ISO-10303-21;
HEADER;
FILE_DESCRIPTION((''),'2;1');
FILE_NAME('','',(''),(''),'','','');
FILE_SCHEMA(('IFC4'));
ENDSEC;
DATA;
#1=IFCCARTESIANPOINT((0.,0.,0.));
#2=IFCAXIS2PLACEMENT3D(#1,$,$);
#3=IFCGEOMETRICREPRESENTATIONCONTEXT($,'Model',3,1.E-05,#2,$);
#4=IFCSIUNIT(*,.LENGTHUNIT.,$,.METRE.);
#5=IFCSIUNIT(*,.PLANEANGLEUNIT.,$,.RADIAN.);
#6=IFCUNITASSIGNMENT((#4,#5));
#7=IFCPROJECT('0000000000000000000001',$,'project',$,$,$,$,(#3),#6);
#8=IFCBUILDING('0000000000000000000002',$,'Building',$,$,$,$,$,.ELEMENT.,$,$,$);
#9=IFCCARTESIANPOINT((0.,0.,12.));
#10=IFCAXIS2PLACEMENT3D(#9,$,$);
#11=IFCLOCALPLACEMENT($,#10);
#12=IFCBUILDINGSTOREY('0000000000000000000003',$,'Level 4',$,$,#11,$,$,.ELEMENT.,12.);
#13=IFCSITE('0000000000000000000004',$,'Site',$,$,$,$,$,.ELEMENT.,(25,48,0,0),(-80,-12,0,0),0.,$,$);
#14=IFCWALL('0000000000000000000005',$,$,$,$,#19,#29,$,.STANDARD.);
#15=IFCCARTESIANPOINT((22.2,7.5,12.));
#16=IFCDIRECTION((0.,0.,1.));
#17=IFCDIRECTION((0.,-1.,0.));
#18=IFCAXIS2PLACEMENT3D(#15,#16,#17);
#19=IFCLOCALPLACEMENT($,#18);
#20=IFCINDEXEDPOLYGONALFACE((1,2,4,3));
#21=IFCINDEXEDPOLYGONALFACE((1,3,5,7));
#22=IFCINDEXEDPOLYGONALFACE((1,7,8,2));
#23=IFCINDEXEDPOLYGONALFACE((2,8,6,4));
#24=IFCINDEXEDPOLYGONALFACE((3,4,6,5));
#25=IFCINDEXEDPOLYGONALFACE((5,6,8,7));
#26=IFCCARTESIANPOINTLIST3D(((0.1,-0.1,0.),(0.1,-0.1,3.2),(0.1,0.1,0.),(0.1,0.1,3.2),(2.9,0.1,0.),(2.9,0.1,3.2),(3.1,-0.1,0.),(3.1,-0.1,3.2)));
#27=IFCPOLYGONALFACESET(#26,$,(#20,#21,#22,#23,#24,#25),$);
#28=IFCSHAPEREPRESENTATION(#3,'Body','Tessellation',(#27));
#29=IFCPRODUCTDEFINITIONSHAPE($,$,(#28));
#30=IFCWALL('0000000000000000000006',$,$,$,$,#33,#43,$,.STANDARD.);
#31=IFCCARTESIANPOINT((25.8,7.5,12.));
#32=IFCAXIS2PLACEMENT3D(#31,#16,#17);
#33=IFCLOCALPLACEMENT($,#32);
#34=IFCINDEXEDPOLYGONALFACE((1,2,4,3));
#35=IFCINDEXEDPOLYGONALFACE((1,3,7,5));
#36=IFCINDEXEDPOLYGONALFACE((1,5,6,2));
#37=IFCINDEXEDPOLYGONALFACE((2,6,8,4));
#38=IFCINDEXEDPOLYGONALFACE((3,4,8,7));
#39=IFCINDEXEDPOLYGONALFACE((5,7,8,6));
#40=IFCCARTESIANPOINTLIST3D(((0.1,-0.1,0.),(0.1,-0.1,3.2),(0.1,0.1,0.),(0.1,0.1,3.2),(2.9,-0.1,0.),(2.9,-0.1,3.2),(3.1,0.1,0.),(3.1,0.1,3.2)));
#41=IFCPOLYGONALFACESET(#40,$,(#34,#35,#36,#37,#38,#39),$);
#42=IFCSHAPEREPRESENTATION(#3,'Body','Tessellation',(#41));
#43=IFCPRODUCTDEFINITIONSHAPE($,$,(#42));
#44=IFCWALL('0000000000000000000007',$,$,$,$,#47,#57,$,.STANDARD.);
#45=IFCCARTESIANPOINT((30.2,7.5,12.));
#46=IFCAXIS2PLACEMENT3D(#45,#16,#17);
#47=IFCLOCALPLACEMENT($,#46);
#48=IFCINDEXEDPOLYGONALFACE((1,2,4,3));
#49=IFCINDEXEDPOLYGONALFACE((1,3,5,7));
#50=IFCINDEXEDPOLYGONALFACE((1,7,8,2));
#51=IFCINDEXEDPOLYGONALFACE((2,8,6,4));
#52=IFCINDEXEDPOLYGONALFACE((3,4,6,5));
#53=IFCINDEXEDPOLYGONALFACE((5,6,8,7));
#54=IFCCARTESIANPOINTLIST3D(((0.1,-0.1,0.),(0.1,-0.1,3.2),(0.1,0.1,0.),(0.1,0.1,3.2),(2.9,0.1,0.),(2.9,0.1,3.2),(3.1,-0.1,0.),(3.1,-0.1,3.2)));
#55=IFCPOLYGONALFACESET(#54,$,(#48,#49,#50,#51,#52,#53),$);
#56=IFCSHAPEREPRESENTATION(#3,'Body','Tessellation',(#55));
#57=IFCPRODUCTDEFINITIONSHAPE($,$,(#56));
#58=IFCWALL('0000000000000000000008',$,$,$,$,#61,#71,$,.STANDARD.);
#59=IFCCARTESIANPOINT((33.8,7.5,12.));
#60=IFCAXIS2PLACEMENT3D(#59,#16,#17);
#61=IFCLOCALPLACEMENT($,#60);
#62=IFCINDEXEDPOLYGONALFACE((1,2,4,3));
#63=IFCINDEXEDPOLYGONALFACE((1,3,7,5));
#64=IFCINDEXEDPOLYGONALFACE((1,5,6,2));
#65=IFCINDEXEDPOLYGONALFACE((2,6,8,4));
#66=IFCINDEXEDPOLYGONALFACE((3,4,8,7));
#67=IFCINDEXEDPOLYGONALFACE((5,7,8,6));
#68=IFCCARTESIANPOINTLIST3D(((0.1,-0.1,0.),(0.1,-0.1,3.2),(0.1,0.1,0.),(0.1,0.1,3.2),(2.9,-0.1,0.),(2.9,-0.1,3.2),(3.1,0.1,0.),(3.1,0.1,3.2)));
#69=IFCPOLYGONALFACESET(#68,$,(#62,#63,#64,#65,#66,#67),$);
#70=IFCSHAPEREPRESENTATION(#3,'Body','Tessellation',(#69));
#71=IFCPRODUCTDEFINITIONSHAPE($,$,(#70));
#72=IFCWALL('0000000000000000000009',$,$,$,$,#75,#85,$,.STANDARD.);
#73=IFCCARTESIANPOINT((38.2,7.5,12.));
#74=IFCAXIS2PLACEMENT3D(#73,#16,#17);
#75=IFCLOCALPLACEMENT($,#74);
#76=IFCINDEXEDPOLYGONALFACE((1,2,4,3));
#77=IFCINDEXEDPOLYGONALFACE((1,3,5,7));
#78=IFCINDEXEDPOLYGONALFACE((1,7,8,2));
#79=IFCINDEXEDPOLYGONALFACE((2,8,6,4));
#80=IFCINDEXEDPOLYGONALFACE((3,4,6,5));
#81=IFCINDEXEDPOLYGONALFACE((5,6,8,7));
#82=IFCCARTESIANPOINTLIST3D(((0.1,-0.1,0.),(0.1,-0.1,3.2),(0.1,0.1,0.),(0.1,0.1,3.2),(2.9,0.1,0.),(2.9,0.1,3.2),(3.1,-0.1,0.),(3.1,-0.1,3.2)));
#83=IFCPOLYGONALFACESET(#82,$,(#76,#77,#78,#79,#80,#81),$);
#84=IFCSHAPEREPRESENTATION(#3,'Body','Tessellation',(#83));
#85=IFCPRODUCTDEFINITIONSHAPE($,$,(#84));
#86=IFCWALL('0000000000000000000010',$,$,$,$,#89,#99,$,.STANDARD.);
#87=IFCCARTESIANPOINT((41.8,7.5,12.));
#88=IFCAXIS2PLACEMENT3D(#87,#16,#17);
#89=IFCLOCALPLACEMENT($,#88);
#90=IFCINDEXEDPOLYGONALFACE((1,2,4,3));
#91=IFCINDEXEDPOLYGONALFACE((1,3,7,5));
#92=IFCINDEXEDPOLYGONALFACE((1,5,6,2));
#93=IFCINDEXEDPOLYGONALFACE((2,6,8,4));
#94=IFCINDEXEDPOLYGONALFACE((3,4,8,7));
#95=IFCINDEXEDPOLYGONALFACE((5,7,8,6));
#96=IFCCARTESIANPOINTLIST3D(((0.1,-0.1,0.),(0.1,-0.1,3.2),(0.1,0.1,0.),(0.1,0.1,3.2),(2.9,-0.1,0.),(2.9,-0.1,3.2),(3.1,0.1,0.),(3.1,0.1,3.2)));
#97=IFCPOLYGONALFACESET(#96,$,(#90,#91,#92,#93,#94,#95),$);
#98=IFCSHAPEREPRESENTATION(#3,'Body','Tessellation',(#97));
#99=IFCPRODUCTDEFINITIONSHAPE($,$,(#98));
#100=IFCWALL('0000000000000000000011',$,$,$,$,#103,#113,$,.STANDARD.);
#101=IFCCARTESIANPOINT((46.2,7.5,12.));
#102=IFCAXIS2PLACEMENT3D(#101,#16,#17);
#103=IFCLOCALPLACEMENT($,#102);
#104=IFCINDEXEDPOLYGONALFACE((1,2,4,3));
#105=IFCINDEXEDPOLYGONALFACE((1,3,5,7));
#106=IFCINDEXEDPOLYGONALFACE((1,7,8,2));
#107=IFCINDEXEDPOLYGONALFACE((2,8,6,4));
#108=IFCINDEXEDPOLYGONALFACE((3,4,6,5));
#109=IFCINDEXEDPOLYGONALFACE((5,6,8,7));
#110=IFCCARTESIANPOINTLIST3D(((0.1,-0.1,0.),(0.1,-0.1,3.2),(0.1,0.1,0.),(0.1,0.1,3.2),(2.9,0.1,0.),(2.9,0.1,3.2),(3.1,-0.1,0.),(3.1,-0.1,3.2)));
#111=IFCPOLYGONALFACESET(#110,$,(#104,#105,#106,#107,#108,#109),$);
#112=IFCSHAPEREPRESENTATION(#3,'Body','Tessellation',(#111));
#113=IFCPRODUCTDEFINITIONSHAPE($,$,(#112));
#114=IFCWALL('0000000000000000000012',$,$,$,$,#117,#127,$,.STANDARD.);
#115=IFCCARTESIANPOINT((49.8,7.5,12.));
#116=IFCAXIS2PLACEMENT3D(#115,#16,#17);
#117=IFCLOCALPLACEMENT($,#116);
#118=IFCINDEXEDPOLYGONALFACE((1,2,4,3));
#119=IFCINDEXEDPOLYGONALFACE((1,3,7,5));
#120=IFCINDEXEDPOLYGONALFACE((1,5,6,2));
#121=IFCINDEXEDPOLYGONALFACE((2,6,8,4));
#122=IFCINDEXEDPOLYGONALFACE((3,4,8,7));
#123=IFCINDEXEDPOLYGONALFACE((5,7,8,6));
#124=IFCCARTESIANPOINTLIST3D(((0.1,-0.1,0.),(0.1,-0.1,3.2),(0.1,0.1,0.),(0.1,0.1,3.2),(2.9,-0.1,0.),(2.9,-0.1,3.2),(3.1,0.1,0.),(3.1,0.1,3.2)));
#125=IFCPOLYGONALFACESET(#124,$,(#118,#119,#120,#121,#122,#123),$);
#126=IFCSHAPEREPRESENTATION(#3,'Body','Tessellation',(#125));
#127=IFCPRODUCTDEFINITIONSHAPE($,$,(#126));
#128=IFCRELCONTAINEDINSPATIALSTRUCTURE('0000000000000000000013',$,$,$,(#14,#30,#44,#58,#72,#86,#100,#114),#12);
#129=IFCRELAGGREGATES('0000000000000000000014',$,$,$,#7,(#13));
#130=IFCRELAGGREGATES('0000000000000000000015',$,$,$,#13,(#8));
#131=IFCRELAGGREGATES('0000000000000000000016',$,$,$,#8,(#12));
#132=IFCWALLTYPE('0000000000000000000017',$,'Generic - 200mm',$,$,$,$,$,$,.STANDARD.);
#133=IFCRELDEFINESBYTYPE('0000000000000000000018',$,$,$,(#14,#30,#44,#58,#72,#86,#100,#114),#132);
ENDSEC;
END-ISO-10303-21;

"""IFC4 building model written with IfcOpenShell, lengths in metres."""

from ifc_helpers import new_model, si_unit, frame, origin, place, context, project, spatial, polyline, outline, extrude, type_object, element, save


model = new_model("IFC4")

# Units and contexts
model_context = context("Model", 3, precision=1e-05, world=origin())
ifc_project = project(units=[si_unit("LENGTHUNIT", "METRE"), si_unit("PLANEANGLEUNIT", "RADIAN")], contexts=[model_context])

# Site, building, storey
site = spatial("IfcSite", under=ifc_project, Name="Site", CompositionType="ELEMENT", RefLatitude=(25, 48, 0, 0), RefLongitude=(-80, -12, 0, 0), RefElevation=0.0)
building = spatial("IfcBuilding", under=site, Name="Building", CompositionType="ELEMENT")
storey_placement = place(None, frame((0.0, 0.0, 12.0)))
storey = spatial("IfcBuildingStorey", under=building, at=storey_placement, Name="Level 4", CompositionType="ELEMENT", Elevation=12.0)

# Shared definitions
wall_type = type_object("IfcWallType", Name="Generic - 200mm", PredefinedType="STANDARD")

# Walls
wall_1_placement = place(None, frame((22.2, 7.5, 12.0), z_axis=(0.0, 0.0, 1.0), x_axis=(0.0, -1.0, 0.0)))
element("IfcWall", 1, at=wall_1_placement, inside=storey, type_object=wall_type, PredefinedType="STANDARD", context=model_context, shape_type="SweptSolid", body=[
    extrude(outline(polyline([(0.1, -0.1), (3.1, -0.1), (2.9, 0.1), (0.1, 0.1), (0.1, -0.1)])), origin(), (0.0, 0.0, 1.0), 3.2),
])
wall_2_placement = place(None, frame((25.8, 7.5, 12.0), z_axis=(0.0, 0.0, 1.0), x_axis=(0.0, -1.0, 0.0)))
element("IfcWall", 2, at=wall_2_placement, inside=storey, type_object=wall_type, PredefinedType="STANDARD", context=model_context, shape_type="SweptSolid", body=[
    extrude(outline(polyline([(0.1, -0.1), (2.9, -0.1), (3.1, 0.1), (0.1, 0.1), (0.1, -0.1)])), origin(), (0.0, 0.0, 1.0), 3.2),
])
wall_3_placement = place(None, frame((30.2, 7.5, 12.0), z_axis=(0.0, 0.0, 1.0), x_axis=(0.0, -1.0, 0.0)))
element("IfcWall", 3, at=wall_3_placement, inside=storey, type_object=wall_type, PredefinedType="STANDARD", context=model_context, shape_type="SweptSolid", body=[
    extrude(outline(polyline([(0.1, -0.1), (3.1, -0.1), (2.9, 0.1), (0.1, 0.1), (0.1, -0.1)])), origin(), (0.0, 0.0, 1.0), 3.2),
])
wall_4_placement = place(None, frame((33.8, 7.5, 12.0), z_axis=(0.0, 0.0, 1.0), x_axis=(0.0, -1.0, 0.0)))
element("IfcWall", 4, at=wall_4_placement, inside=storey, type_object=wall_type, PredefinedType="STANDARD", context=model_context, shape_type="SweptSolid", body=[
    extrude(outline(polyline([(0.1, -0.1), (2.9, -0.1), (3.1, 0.1), (0.1, 0.1), (0.1, -0.1)])), origin(), (0.0, 0.0, 1.0), 3.2),
])
wall_5_placement = place(None, frame((38.2, 7.5, 12.0), z_axis=(0.0, 0.0, 1.0), x_axis=(0.0, -1.0, 0.0)))
element("IfcWall", 5, at=wall_5_placement, inside=storey, type_object=wall_type, PredefinedType="STANDARD", context=model_context, shape_type="SweptSolid", body=[
    extrude(outline(polyline([(0.1, -0.1), (3.1, -0.1), (2.9, 0.1), (0.1, 0.1), (0.1, -0.1)])), origin(), (0.0, 0.0, 1.0), 3.2),
])
wall_6_placement = place(None, frame((41.8, 7.5, 12.0), z_axis=(0.0, 0.0, 1.0), x_axis=(0.0, -1.0, 0.0)))
element("IfcWall", 6, at=wall_6_placement, inside=storey, type_object=wall_type, PredefinedType="STANDARD", context=model_context, shape_type="SweptSolid", body=[
    extrude(outline(polyline([(0.1, -0.1), (2.9, -0.1), (3.1, 0.1), (0.1, 0.1), (0.1, -0.1)])), origin(), (0.0, 0.0, 1.0), 3.2),
])
wall_7_placement = place(None, frame((46.2, 7.5, 12.0), z_axis=(0.0, 0.0, 1.0), x_axis=(0.0, -1.0, 0.0)))
element("IfcWall", 7, at=wall_7_placement, inside=storey, type_object=wall_type, PredefinedType="STANDARD", context=model_context, shape_type="SweptSolid", body=[
    extrude(outline(polyline([(0.1, -0.1), (3.1, -0.1), (2.9, 0.1), (0.1, 0.1), (0.1, -0.1)])), origin(), (0.0, 0.0, 1.0), 3.2),
])
wall_8_placement = place(None, frame((49.8, 7.5, 12.0), z_axis=(0.0, 0.0, 1.0), x_axis=(0.0, -1.0, 0.0)))
element("IfcWall", 8, at=wall_8_placement, inside=storey, type_object=wall_type, PredefinedType="STANDARD", context=model_context, shape_type="SweptSolid", body=[
    extrude(outline(polyline([(0.1, -0.1), (2.9, -0.1), (3.1, 0.1), (0.1, 0.1), (0.1, -0.1)])), origin(), (0.0, 0.0, 1.0), 3.2),
])

save(model, "model.ifc")
